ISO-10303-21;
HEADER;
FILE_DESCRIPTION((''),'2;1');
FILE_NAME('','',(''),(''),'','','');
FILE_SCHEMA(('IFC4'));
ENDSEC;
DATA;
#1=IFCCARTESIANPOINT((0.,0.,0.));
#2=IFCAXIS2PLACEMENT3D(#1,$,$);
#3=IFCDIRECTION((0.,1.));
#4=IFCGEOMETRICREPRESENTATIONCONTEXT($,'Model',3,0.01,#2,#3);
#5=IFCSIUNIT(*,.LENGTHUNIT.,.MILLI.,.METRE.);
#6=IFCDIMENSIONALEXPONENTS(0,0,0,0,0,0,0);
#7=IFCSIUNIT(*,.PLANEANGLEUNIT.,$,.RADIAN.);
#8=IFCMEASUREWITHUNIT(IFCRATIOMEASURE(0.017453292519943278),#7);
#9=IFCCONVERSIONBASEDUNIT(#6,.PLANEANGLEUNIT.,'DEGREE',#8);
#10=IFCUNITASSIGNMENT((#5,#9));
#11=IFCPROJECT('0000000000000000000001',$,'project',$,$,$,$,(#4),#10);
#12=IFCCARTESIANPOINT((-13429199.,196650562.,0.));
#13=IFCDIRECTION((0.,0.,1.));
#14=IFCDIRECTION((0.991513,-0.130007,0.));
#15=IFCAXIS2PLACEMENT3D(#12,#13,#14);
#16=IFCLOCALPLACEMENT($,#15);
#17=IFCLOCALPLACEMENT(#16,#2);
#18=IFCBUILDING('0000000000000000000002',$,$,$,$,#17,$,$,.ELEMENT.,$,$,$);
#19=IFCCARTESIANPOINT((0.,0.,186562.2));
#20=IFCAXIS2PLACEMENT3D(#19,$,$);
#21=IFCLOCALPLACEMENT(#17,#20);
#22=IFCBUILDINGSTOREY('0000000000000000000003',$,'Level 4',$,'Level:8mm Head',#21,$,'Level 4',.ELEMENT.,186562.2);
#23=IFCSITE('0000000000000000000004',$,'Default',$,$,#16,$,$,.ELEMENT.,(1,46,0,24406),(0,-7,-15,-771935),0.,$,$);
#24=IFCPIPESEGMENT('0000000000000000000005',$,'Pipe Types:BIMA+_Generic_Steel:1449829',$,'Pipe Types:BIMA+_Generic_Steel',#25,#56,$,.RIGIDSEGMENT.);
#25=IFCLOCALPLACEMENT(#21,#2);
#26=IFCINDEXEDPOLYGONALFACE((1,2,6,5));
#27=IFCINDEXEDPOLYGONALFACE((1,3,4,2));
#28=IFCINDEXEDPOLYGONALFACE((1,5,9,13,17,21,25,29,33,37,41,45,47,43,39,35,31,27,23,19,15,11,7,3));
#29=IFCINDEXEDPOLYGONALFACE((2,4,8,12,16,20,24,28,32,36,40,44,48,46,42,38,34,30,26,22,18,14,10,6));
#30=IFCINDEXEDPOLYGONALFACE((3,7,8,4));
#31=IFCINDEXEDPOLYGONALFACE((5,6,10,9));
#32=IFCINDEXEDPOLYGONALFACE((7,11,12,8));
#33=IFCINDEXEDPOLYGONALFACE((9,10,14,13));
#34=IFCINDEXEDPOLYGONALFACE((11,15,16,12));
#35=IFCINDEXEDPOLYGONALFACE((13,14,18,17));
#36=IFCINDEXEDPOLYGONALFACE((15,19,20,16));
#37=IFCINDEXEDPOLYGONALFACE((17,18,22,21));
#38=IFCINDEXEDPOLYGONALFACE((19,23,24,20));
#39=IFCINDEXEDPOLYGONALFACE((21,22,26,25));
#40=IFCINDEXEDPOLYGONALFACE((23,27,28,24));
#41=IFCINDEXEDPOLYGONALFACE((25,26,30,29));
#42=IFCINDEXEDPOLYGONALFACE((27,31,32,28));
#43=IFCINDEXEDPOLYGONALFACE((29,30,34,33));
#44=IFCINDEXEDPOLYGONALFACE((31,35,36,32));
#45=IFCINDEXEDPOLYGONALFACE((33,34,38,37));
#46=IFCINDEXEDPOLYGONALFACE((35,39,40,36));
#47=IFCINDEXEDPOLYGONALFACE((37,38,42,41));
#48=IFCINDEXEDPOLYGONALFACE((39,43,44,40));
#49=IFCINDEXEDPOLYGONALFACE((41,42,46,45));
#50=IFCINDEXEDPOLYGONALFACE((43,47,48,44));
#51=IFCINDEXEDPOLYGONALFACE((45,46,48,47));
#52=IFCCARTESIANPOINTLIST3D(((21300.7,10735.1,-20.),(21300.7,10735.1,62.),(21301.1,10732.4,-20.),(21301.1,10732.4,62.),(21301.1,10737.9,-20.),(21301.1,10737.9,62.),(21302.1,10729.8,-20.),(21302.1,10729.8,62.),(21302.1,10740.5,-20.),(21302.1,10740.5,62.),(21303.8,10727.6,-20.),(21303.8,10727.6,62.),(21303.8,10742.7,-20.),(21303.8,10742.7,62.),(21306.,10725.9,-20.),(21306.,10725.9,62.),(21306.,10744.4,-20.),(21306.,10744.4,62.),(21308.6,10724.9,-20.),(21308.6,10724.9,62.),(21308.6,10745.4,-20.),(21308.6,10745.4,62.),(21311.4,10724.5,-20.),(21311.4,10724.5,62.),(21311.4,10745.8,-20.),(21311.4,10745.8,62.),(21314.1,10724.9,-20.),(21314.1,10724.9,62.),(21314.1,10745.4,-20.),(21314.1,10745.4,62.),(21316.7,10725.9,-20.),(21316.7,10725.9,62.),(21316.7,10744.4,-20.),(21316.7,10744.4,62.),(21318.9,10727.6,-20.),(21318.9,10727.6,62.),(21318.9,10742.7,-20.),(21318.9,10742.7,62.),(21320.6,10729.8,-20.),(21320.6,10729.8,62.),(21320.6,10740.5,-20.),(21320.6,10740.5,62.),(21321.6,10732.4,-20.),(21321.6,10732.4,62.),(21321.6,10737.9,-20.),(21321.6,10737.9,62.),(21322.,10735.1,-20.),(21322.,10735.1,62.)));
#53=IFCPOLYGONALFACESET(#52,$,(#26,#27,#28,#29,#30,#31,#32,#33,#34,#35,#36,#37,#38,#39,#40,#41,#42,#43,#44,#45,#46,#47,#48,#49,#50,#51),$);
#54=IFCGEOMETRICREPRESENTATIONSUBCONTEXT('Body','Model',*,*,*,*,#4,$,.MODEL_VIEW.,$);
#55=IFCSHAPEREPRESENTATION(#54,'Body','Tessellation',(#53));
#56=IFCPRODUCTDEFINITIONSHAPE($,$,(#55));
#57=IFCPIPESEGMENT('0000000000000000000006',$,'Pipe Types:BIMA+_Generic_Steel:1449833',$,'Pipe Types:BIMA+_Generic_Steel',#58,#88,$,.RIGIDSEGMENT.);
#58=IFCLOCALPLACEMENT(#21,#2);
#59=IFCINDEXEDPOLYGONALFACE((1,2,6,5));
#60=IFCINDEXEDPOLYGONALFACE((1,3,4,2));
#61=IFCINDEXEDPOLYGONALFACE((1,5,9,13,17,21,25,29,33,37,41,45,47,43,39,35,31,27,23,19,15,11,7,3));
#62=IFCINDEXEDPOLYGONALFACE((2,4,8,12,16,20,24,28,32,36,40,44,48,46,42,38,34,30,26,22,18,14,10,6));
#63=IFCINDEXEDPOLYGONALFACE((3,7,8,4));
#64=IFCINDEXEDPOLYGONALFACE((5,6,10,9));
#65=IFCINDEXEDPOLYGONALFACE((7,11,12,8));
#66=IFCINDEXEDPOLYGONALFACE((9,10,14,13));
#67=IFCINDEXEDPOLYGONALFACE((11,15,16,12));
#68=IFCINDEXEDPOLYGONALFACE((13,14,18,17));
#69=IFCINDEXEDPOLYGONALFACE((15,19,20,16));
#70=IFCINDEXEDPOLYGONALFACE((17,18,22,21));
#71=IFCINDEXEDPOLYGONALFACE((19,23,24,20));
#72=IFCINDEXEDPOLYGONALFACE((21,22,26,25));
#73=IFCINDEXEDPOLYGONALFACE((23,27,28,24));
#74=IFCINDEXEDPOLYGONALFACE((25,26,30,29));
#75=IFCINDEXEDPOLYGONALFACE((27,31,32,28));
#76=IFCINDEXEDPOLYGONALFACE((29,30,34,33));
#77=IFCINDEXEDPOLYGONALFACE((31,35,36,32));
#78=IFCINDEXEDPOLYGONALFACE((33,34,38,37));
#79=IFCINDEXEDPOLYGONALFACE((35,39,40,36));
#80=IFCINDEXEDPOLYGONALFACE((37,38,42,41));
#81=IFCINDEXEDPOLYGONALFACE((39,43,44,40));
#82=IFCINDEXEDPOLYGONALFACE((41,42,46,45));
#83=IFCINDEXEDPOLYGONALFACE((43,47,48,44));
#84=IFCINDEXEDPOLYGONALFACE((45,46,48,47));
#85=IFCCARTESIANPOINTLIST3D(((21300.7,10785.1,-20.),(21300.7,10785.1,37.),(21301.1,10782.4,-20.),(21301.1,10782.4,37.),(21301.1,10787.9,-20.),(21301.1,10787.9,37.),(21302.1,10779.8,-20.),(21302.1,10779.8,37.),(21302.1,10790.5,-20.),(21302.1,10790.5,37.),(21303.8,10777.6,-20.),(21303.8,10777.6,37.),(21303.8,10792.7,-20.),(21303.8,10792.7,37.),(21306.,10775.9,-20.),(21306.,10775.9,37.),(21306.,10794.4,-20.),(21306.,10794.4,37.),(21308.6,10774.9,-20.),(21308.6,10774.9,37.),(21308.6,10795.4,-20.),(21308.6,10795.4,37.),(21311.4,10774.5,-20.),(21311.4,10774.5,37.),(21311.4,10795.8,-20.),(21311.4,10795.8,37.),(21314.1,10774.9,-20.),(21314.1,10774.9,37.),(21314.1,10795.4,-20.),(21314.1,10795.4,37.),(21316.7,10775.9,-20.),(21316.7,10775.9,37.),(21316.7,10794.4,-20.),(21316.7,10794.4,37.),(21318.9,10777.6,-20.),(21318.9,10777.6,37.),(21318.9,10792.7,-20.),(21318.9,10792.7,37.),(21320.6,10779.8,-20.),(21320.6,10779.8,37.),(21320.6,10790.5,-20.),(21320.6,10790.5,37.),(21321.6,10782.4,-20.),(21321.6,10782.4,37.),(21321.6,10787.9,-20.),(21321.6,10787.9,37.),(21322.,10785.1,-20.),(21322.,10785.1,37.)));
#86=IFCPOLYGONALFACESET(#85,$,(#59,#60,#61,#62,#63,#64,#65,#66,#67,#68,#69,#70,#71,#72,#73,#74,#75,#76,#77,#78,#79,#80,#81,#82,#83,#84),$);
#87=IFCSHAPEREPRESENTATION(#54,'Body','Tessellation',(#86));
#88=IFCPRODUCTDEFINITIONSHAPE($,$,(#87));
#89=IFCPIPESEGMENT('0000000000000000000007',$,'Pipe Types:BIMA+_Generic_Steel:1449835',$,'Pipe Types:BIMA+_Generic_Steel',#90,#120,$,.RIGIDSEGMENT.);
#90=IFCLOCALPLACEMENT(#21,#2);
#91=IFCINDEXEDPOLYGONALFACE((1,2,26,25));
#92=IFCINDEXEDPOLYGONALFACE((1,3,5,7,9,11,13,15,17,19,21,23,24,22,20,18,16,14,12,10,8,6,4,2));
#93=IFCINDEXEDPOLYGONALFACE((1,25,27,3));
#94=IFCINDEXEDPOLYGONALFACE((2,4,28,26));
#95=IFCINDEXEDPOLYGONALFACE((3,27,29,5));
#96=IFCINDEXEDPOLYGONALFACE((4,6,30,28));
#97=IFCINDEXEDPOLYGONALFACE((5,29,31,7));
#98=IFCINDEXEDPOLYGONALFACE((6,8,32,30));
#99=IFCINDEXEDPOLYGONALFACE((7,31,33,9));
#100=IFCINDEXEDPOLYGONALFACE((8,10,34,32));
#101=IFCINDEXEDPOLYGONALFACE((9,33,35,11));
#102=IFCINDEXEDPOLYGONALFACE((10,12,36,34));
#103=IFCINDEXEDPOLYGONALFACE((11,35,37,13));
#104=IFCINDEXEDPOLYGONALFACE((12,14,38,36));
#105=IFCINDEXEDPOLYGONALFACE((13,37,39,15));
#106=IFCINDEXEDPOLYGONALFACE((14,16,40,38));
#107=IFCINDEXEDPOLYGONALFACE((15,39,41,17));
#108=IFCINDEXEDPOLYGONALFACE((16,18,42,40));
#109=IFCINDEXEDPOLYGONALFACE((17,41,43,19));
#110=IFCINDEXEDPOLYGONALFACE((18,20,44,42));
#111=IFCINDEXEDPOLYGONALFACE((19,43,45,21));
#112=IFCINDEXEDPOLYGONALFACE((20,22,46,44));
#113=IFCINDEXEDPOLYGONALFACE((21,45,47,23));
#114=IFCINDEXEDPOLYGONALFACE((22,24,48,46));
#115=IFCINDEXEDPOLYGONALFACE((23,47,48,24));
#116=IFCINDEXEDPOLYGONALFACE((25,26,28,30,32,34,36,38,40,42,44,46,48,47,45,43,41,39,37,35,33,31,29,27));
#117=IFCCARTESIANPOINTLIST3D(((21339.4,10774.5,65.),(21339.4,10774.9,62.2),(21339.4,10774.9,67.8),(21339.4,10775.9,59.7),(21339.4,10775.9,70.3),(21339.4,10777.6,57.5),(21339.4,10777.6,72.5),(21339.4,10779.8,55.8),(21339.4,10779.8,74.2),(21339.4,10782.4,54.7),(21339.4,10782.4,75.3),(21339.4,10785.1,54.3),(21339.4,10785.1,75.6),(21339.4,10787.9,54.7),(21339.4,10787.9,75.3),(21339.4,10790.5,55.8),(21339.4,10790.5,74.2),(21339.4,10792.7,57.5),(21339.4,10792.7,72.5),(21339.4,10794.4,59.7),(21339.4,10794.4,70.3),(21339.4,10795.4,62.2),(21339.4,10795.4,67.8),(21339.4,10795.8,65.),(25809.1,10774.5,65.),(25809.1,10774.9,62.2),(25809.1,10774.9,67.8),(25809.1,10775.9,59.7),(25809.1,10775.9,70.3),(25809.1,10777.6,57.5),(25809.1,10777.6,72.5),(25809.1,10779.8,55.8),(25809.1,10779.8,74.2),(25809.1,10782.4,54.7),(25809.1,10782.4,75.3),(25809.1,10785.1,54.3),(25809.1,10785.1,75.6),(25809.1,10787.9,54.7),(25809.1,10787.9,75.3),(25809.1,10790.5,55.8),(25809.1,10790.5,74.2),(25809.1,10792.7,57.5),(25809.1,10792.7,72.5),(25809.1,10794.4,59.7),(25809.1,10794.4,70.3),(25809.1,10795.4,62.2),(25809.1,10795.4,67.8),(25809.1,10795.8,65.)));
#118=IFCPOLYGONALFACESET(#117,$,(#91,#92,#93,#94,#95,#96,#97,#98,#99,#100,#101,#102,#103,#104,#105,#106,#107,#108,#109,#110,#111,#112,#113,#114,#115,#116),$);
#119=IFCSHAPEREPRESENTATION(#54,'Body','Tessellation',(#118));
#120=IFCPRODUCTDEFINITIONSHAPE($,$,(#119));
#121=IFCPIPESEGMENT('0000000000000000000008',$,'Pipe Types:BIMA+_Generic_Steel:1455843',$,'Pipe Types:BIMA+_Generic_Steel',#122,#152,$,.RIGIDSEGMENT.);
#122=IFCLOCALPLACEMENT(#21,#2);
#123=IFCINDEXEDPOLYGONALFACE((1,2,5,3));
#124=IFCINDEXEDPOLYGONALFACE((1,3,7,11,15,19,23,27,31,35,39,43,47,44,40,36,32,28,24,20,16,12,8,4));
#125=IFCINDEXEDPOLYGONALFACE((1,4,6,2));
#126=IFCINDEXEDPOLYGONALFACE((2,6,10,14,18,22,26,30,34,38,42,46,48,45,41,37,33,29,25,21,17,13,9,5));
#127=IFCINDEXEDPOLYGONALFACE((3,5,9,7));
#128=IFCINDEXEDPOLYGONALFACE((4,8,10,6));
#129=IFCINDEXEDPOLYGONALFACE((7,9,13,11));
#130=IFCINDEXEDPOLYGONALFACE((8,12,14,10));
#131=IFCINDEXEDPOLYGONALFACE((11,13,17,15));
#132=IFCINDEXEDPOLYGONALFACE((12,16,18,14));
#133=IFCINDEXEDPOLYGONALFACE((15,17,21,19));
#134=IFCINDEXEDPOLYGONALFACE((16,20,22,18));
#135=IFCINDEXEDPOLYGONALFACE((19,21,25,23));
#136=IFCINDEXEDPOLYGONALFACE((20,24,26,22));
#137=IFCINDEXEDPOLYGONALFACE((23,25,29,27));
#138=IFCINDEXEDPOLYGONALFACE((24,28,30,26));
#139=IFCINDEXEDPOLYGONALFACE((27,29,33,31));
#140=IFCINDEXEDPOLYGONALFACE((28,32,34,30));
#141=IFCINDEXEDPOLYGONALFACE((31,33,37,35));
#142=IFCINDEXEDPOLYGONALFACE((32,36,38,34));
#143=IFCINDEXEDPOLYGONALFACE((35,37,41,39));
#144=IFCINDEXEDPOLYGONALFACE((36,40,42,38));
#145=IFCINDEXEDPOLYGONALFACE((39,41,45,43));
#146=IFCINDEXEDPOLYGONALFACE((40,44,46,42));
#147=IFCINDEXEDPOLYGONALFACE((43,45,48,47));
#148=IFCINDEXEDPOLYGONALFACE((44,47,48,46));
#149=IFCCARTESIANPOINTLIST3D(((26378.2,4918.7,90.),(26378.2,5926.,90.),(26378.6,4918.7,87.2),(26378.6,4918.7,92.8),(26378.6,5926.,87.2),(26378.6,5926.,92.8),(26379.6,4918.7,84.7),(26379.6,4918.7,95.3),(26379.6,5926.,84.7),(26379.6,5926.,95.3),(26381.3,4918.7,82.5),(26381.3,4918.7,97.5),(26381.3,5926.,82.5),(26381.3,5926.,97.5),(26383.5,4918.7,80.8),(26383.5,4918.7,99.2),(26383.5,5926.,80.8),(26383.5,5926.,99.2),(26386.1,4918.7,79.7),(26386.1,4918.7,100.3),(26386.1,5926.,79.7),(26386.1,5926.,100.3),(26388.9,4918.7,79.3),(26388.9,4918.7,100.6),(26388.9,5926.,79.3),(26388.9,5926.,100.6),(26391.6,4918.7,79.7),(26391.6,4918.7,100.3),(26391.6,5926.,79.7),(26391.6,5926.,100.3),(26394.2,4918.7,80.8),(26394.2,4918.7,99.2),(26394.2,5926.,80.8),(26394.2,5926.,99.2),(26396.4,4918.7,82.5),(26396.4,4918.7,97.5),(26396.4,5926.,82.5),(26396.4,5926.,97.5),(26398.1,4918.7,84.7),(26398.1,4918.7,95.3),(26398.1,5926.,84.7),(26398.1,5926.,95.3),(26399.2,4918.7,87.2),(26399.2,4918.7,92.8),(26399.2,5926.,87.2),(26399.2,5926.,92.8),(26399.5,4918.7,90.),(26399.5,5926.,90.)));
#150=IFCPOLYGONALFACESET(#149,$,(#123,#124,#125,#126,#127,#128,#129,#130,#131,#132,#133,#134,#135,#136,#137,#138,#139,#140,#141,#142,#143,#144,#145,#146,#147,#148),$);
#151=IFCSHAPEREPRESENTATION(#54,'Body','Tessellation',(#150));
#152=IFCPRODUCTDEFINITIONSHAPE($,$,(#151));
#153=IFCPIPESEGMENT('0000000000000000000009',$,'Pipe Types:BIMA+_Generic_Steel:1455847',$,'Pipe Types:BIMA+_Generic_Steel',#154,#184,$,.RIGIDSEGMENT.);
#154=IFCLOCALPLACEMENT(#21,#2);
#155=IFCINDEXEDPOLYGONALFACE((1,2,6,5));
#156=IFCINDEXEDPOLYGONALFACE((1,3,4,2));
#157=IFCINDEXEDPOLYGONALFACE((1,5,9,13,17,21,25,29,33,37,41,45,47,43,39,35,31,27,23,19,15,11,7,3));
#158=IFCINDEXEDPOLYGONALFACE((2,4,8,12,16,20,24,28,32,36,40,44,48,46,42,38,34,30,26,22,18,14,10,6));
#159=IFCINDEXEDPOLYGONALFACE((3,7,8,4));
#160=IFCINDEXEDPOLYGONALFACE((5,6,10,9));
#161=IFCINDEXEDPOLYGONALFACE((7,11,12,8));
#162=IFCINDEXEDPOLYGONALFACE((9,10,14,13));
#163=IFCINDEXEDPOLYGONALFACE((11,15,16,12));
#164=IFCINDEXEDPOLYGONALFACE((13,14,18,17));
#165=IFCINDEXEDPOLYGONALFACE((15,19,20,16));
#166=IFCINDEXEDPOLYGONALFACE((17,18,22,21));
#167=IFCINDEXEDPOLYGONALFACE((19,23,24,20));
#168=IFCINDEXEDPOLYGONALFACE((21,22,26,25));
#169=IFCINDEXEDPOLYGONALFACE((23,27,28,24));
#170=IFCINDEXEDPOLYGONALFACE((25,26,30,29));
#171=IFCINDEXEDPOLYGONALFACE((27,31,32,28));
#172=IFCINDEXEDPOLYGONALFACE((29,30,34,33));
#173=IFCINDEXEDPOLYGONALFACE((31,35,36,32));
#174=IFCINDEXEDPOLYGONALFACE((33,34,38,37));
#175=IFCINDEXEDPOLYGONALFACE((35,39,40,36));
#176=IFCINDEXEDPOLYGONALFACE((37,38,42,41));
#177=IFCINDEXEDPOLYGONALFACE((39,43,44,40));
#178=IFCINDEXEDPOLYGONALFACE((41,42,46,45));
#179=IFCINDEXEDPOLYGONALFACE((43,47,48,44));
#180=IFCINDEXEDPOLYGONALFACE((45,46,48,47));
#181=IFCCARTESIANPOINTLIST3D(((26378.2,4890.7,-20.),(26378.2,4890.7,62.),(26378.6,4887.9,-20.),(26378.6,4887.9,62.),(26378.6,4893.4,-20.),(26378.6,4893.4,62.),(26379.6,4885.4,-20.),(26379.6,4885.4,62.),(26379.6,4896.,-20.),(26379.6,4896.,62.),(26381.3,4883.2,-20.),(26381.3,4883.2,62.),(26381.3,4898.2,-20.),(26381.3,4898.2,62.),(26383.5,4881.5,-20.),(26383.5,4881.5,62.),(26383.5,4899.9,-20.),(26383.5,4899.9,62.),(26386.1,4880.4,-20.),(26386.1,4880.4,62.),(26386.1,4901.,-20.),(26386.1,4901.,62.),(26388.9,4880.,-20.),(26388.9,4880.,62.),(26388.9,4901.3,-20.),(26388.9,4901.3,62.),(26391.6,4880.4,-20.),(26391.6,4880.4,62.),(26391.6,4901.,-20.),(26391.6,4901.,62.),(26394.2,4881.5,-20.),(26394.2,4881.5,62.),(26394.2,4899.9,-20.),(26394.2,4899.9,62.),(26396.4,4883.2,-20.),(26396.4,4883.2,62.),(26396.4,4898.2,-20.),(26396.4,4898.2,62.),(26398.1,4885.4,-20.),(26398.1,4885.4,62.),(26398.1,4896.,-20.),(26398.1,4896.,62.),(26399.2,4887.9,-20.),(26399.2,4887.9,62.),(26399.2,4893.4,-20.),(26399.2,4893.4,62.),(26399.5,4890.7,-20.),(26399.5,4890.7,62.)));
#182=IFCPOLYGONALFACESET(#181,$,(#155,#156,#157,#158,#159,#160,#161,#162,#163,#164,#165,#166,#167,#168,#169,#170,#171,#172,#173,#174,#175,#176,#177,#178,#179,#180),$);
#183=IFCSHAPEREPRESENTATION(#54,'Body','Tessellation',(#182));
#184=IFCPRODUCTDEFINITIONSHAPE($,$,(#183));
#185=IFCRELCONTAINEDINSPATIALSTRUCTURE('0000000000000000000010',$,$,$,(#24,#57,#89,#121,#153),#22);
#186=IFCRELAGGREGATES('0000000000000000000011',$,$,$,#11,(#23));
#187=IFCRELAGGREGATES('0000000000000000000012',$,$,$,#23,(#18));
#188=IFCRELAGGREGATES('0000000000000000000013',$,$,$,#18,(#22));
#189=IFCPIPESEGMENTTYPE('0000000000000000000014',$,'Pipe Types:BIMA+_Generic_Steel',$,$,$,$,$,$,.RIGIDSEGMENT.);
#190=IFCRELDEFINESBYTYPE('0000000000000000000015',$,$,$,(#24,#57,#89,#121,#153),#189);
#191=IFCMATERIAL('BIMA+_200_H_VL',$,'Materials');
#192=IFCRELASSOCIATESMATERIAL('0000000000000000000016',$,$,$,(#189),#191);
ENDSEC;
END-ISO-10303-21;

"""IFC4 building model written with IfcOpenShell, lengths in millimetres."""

from ifc_helpers import new_model, entity, si_unit, converted_unit, direction, frame, origin, place, context, subcontext, project, spatial, arc, indexed_curve, outline, extrude, material, type_object, element, save


model = new_model("IFC4")

# Units and contexts
model_context = context("Model", 3, precision=0.01, world=origin(), true_north=direction((0.0, 1.0)))
body_context = subcontext(model_context, "Body", "Model", "MODEL_VIEW")
ifc_project = project(units=[si_unit("LENGTHUNIT", "METRE", prefix="MILLI"), converted_unit("PLANEANGLEUNIT", "DEGREE", entity("IfcRatioMeasure", 0.017453292519943278), si_unit("PLANEANGLEUNIT", "RADIAN"), dimensions=[0, 0, 0, 0, 0, 0, 0])], contexts=[model_context])

# Site, building, storey
site_placement = place(None, frame((-13429199.0, 196650562.0, 0.0), z_axis=(0.0, 0.0, 1.0), x_axis=(0.991513, -0.130007, 0.0)))
site = spatial("IfcSite", under=ifc_project, at=site_placement, Name="Default", CompositionType="ELEMENT", RefLatitude=(1, 46, 0, 24406), RefLongitude=(0, -7, -15, -771935), RefElevation=0.0)
building_placement = place(site_placement, origin())
building = spatial("IfcBuilding", under=site, at=building_placement, CompositionType="ELEMENT")
storey_placement = place(building_placement, frame((0.0, 0.0, 186562.2)))
storey = spatial("IfcBuildingStorey", under=building, at=storey_placement, Name="Level 4", ObjectType="Level:8mm Head", LongName="Level 4", CompositionType="ELEMENT", Elevation=186562.2)

# Pipe segments
ifc_material = material(Name="BIMA+_200_H_VL", Category="Materials")
pipe_segment_type = type_object("IfcPipeSegmentType", Name="Pipe Types:BIMA+_Generic_Steel", PredefinedType="RIGIDSEGMENT", material=ifc_material)
pipe_segment_1_placement = place(storey_placement, frame((21299.1, 10722.9, -20.0)))
element("IfcPipeSegment", 1, at=pipe_segment_1_placement, inside=storey, type_object=pipe_segment_type, Name="Pipe Types:BIMA+_Generic_Steel:1449829", ObjectType="Pipe Types:BIMA+_Generic_Steel", PredefinedType="RIGIDSEGMENT", context=body_context, shape_type="SweptSolid", body=[
    extrude(outline(indexed_curve([(10.7, 0.0), (7.5, 7.5), (0.0, 10.6), (-7.5, 7.5), (-10.7, 0.0), (-7.5, -7.5), (0.0, -10.6), (7.5, -7.5)], segments=[arc(1, 2, 3), arc(3, 4, 5), arc(5, 6, 7), arc(7, 8, 1)], self_intersect=False)), frame((12.2, 12.2, 0.0), z_axis=(0.0, 0.0, 1.0), x_axis=(-1.0, 0.0, 0.0)), (0.0, 0.0, 1.0), 82.0),
])
pipe_segment_2_placement = place(storey_placement, frame((21299.1, 10772.9, -20.0)))
element("IfcPipeSegment", 2, at=pipe_segment_2_placement, inside=storey, type_object=pipe_segment_type, Name="Pipe Types:BIMA+_Generic_Steel:1449833", ObjectType="Pipe Types:BIMA+_Generic_Steel", PredefinedType="RIGIDSEGMENT", context=body_context, shape_type="SweptSolid", body=[
    extrude(outline(indexed_curve([(10.7, 0.0), (7.5, 7.5), (0.0, 10.7), (-7.5, 7.5), (-10.7, 0.0), (-7.5, -7.5), (0.0, -10.6), (7.5, -7.5)], segments=[arc(1, 2, 3), arc(3, 4, 5), arc(5, 6, 7), arc(7, 8, 1)], self_intersect=False)), frame((12.2, 12.2, 0.0), z_axis=(0.0, 0.0, 1.0), x_axis=(-1.0, 0.0, 0.0)), (0.0, 0.0, 1.0), 57.0),
])
pipe_segment_3_placement = place(storey_placement, frame((21339.4, 10772.9, 52.8)))
element("IfcPipeSegment", 3, at=pipe_segment_3_placement, inside=storey, type_object=pipe_segment_type, Name="Pipe Types:BIMA+_Generic_Steel:1449835", ObjectType="Pipe Types:BIMA+_Generic_Steel", PredefinedType="RIGIDSEGMENT", context=body_context, shape_type="SweptSolid", body=[
    extrude(outline(indexed_curve([(10.7, 0.0), (7.5, 7.5), (0.0, 10.6), (-7.5, 7.5), (-10.6, 0.0), (-7.5, -7.5), (0.0, -10.7), (7.5, -7.5)], segments=[arc(1, 2, 3), arc(3, 4, 5), arc(5, 6, 7), arc(7, 8, 1)], self_intersect=False)), frame((0.0, 12.2, 12.2), z_axis=(1.0, 0.0, 0.0), x_axis=(0.0, 1.0, 0.0)), (0.0, 0.0, 1.0), 4469.7),
])
pipe_segment_4_placement = place(storey_placement, frame((26376.6, 4918.7, 77.8)))
element("IfcPipeSegment", 4, at=pipe_segment_4_placement, inside=storey, type_object=pipe_segment_type, Name="Pipe Types:BIMA+_Generic_Steel:1455843", ObjectType="Pipe Types:BIMA+_Generic_Steel", PredefinedType="RIGIDSEGMENT", context=body_context, shape_type="SweptSolid", body=[
    extrude(outline(indexed_curve([(10.7, 0.0), (7.5, 7.5), (0.0, 10.7), (-7.5, 7.5), (-10.7, 0.0), (-7.5, -7.5), (0.0, -10.7), (7.5, -7.5)], segments=[arc(1, 2, 3), arc(3, 4, 5), arc(5, 6, 7), arc(7, 8, 1)], self_intersect=False)), frame((12.2, 0.0, 12.2), z_axis=(0.0, 1.0, 0.0), x_axis=(-1.0, 0.0, 0.0)), (0.0, 0.0, 1.0), 1007.4),
])
pipe_segment_5_placement = place(storey_placement, frame((26376.6, 4878.4, 62.0)))
element("IfcPipeSegment", 5, at=pipe_segment_5_placement, inside=storey, type_object=pipe_segment_type, Name="Pipe Types:BIMA+_Generic_Steel:1455847", ObjectType="Pipe Types:BIMA+_Generic_Steel", PredefinedType="RIGIDSEGMENT", context=body_context, shape_type="SweptSolid", body=[
    extrude(outline(indexed_curve([(10.7, 0.0), (7.5, 7.5), (0.0, 10.6), (-7.5, 7.5), (-10.7, 0.0), (-7.5, -7.5), (0.0, -10.6), (7.5, -7.5)], segments=[arc(1, 2, 3), arc(3, 4, 5), arc(5, 6, 7), arc(7, 8, 1)], self_intersect=False)), frame((12.2, 12.2, -82.0)), (0.0, 0.0, 1.0), 82.0),
])

save(model, "model.ifc")
